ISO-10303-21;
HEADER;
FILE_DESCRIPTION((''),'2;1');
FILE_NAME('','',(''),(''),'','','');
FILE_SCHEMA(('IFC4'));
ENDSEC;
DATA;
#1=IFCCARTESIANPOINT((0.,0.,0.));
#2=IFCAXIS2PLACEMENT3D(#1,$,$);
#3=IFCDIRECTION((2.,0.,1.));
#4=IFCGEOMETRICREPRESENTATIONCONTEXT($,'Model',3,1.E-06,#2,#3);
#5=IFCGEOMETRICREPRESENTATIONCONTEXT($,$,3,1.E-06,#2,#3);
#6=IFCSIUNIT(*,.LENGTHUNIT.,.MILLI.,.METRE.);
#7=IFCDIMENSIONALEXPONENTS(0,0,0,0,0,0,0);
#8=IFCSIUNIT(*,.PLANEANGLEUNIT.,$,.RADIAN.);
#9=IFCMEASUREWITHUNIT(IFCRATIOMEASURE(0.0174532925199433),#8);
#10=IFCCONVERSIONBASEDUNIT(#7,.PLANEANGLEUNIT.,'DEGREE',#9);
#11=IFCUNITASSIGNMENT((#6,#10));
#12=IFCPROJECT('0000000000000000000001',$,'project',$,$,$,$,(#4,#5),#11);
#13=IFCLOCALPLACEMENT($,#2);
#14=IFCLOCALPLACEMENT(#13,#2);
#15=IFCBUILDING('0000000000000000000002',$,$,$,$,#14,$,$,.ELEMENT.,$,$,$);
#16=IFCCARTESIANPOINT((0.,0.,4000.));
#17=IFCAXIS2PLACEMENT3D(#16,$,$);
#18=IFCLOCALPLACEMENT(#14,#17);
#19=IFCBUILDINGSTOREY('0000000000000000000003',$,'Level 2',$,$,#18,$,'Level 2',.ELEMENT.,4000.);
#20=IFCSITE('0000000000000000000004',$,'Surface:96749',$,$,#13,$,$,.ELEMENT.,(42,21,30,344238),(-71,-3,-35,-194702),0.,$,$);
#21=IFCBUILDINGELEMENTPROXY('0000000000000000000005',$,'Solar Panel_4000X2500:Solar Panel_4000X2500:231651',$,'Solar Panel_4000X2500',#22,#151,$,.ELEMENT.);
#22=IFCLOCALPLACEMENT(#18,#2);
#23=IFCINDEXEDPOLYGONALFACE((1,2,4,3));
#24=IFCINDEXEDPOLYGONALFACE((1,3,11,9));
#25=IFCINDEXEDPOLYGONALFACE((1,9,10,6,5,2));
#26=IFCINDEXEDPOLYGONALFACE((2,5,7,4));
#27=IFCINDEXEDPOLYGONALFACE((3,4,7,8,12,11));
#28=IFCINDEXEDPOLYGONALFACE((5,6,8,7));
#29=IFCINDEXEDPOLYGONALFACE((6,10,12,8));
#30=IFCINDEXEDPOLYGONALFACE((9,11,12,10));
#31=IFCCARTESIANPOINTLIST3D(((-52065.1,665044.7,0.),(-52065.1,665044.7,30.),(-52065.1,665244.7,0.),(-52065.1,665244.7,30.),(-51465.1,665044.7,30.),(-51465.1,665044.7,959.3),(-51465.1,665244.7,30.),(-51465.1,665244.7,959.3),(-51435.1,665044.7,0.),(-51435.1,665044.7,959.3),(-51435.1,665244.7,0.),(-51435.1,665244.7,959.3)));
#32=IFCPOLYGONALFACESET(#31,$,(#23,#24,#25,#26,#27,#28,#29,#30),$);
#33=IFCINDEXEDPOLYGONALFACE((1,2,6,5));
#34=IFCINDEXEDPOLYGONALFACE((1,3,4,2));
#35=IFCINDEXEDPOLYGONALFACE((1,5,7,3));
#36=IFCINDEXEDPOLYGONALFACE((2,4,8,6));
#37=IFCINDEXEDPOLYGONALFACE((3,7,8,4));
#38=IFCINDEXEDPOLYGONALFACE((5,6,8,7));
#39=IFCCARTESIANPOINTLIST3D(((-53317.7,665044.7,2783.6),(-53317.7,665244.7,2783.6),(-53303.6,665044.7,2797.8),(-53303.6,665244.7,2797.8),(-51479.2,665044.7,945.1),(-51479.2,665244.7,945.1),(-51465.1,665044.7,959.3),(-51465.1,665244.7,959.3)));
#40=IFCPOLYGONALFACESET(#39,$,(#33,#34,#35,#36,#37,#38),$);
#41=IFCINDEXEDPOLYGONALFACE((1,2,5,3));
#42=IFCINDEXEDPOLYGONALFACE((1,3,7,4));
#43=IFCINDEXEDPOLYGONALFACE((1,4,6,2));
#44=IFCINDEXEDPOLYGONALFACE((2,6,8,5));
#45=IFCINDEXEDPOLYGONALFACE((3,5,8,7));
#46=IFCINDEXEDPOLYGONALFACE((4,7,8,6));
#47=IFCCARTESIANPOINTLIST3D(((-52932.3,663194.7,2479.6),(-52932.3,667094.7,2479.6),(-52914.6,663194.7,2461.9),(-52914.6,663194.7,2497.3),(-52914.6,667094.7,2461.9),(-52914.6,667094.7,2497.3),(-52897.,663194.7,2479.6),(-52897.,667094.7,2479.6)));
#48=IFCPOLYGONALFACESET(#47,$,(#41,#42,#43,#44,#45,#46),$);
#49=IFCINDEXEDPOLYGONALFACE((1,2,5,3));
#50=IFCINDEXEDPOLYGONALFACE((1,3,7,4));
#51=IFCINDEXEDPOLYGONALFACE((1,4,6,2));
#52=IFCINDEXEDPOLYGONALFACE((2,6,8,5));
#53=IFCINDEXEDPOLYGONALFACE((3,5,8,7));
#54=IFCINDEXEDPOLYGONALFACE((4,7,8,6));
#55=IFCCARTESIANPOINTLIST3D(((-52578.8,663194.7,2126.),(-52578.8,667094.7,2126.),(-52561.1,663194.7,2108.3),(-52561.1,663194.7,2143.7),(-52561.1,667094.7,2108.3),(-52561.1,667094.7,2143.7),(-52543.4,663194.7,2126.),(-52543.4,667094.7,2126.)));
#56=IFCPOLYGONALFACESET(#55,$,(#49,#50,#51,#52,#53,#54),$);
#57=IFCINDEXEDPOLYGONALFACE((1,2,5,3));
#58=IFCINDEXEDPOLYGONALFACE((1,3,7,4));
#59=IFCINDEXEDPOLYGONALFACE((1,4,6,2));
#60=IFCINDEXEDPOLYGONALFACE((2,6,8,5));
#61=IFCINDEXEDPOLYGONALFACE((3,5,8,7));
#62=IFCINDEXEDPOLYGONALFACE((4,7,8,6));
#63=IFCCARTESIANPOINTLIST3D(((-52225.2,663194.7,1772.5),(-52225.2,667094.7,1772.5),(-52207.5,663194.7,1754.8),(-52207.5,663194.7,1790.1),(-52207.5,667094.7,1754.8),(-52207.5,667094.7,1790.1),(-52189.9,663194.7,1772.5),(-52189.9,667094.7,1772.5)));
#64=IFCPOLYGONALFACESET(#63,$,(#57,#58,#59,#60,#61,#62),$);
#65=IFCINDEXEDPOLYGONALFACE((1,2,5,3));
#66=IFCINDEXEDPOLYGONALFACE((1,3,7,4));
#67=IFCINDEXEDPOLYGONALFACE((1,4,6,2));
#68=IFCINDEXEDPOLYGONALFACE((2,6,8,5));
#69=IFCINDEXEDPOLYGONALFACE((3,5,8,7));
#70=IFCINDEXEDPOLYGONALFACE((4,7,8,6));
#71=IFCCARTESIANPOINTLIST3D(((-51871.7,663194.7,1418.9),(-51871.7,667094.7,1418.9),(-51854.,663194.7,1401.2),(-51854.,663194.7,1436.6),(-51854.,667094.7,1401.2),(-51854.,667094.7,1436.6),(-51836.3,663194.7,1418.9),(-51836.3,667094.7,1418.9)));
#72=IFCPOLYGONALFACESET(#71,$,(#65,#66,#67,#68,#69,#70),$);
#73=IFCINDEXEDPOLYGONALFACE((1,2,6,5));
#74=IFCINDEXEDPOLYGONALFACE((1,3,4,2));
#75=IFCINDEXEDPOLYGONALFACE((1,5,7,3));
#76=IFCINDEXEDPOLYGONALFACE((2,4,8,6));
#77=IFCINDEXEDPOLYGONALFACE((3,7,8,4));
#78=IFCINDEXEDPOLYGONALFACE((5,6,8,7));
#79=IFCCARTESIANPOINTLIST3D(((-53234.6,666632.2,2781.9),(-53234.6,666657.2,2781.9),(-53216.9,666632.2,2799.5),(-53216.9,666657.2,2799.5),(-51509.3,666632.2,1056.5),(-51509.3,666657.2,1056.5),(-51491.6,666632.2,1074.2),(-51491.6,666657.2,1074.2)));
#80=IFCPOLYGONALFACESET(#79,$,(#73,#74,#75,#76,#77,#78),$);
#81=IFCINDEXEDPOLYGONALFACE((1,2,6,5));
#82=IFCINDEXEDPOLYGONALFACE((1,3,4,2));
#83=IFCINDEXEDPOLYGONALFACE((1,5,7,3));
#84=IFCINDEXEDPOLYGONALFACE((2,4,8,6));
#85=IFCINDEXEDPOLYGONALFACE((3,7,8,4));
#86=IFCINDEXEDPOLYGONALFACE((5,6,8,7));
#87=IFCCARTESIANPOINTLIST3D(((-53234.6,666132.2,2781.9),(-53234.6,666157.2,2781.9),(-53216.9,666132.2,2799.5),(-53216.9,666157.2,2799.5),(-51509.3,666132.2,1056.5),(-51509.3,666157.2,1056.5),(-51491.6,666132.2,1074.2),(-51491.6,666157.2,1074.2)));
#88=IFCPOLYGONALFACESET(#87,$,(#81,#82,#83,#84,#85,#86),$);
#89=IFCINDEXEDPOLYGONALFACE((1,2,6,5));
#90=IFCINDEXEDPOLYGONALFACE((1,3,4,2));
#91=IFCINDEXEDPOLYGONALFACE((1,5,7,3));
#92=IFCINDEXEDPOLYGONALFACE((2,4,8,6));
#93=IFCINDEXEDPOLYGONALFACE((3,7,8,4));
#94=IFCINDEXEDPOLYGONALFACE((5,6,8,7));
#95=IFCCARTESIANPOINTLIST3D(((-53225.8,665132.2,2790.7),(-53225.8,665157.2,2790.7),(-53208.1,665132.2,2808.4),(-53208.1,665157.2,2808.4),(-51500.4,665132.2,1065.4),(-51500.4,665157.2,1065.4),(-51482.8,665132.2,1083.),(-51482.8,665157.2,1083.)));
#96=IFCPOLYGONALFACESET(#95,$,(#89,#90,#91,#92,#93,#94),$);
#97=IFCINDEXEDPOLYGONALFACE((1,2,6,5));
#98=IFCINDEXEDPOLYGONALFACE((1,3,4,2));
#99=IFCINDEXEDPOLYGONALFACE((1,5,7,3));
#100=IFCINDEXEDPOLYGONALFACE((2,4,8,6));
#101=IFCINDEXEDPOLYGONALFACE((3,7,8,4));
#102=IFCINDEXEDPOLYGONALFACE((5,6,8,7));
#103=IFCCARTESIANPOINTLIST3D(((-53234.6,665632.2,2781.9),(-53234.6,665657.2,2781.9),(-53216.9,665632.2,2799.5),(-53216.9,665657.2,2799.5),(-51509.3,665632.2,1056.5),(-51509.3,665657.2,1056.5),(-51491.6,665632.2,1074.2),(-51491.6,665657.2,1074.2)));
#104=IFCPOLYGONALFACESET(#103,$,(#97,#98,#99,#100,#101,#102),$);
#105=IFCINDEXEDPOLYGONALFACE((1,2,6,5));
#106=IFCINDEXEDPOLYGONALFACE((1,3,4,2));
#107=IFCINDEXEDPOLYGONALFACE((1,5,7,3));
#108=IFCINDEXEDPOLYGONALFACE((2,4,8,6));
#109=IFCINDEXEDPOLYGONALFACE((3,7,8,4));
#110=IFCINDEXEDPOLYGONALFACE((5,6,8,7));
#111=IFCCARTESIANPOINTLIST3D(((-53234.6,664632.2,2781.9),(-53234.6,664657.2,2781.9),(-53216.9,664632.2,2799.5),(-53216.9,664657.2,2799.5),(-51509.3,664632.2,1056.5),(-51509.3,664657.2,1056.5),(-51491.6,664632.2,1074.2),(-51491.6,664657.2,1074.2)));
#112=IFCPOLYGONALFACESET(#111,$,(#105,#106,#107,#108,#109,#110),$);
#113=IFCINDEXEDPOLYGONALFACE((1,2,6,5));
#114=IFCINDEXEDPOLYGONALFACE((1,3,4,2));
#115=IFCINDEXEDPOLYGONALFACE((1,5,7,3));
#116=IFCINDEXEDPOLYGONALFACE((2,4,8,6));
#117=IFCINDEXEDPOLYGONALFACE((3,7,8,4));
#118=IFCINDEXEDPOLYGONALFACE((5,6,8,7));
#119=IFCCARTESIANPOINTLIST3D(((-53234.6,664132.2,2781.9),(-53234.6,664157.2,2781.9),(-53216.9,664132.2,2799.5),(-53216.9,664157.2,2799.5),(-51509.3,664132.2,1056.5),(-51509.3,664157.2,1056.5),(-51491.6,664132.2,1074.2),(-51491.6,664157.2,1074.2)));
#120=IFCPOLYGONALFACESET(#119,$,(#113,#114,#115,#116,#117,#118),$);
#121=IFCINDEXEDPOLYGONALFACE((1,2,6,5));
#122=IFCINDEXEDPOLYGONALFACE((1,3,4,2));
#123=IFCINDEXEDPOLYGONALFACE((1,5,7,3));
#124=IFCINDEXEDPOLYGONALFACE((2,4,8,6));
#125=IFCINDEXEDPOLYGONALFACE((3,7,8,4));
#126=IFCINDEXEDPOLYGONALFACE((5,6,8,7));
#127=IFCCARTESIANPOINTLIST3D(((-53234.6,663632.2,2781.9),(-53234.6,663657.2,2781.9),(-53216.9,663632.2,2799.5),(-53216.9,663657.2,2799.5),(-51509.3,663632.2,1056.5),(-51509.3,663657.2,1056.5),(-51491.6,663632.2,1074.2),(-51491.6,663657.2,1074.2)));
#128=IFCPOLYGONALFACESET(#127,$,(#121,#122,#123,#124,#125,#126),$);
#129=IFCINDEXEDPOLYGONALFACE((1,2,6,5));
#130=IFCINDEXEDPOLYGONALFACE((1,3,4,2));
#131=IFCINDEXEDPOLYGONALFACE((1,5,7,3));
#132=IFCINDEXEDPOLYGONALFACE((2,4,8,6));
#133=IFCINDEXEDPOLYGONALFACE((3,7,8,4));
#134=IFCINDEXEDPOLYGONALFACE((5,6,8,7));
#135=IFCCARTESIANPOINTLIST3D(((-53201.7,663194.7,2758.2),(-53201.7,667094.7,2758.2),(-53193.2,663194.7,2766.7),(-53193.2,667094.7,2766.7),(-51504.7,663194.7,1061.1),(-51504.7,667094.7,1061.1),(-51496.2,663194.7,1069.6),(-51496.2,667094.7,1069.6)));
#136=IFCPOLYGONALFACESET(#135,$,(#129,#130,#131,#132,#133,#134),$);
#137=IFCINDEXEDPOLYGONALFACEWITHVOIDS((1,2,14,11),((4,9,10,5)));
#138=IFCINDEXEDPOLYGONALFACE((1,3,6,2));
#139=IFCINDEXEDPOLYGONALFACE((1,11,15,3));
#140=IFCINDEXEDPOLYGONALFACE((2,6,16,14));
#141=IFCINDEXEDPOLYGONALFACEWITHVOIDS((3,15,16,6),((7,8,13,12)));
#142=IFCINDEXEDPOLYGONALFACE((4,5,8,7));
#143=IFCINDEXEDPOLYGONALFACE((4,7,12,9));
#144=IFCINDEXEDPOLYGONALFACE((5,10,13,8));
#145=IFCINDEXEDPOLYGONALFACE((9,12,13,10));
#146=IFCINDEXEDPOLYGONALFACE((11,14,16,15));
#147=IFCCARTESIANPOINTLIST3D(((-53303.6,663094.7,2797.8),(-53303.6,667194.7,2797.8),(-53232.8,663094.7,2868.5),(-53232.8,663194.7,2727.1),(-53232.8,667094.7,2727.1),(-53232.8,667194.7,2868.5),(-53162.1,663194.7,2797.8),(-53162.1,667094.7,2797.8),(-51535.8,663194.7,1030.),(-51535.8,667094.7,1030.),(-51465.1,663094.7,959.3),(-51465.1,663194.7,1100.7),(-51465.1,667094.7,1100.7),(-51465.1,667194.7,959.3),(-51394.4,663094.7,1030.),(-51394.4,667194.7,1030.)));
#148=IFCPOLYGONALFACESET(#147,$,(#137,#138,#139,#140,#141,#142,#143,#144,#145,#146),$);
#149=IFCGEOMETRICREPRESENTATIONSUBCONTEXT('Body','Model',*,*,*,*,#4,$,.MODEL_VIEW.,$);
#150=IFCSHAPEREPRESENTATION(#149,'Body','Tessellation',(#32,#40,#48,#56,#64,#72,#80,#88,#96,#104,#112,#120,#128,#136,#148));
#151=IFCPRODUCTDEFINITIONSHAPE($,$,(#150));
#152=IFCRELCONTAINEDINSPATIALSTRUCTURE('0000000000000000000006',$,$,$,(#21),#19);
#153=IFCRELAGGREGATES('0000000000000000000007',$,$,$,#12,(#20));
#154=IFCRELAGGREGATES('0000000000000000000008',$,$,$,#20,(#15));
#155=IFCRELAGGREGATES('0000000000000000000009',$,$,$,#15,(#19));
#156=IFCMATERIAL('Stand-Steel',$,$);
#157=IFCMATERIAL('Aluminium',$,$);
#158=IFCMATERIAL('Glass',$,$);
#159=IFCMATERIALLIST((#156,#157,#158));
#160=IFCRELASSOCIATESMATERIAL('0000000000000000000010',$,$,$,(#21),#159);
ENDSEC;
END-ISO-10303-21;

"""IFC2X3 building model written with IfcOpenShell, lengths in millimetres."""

from ifc_helpers import new_model, entity, si_unit, converted_unit, direction, frame, frame_2d, origin, origin_2d_with_axis, place, context, subcontext, project, spatial, polyline, rectangle, outline, extrude, source, transform, mapped, material, material_list, element, save


model = new_model("IFC2X3")

# Units and contexts
model_context = context("Model", 3, precision=1e-06, world=origin(), true_north=direction((2.0, 0.0, 1.0)))
context_of_model = context(None, 3, precision=1e-06, world=origin(), true_north=direction((2.0, 0.0, 1.0)))
body_context = subcontext(model_context, "Body", "Model", "MODEL_VIEW")
ifc_project = project(units=[si_unit("LENGTHUNIT", "METRE", prefix="MILLI"), converted_unit("PLANEANGLEUNIT", "DEGREE", entity("IfcRatioMeasure", 0.0174532925199433), si_unit("PLANEANGLEUNIT", "RADIAN"), dimensions=[0, 0, 0, 0, 0, 0, 0])], contexts=[model_context, context_of_model])

# Site, building, storey
site_placement = place(None, origin())
site = spatial("IfcSite", under=ifc_project, at=site_placement, Name="Surface:96749", CompositionType="ELEMENT", RefLatitude=(42, 21, 30, 344238), RefLongitude=(-71, -3, -35, -194702), RefElevation=0.0)
building_placement = place(site_placement, origin())
building = spatial("IfcBuilding", under=site, at=building_placement, CompositionType="ELEMENT")
storey_placement = place(building_placement, frame((0.0, 0.0, 4000.0)))
storey = spatial("IfcBuildingStorey", under=building, at=storey_placement, Name="Level 2", LongName="Level 2", CompositionType="ELEMENT", Elevation=4000.0)

# Building element proxy
ifc_material_1 = material(Name="Stand-Steel")
ifc_material_2 = material(Name="Aluminium")
ifc_material_3 = material(Name="Glass")
shared_shape = source(origin(), body_context, "Body", "SweptSolid", [
    extrude(outline(polyline([(-629.5, -220.0), (329.8, -220.0), (329.8, 410.0), (299.8, 410.0), (299.8, -190.0), (-629.5, -190.0), (-629.5, -220.0)])), frame((-190.0, -100.0, 299.8), z_axis=(0.0, 1.0, 0.0), x_axis=(0.0, 0.0, -1.0)), (0.0, 0.0, 1.0), 200.0),
    extrude(rectangle(XDim=20.0, YDim=200.0, at=frame_2d((0.0, 0.0), x_axis=(0.0, 1.0))), frame((-7.1, 0.0, 922.2), z_axis=(-0.707107, 0.0, 0.707107), x_axis=(0.0, 1.0, 0.0)), (0.0, 0.0, 1.0), 2600.0),
    extrude(rectangle(XDim=25.0, YDim=25.0, at=frame_2d((0.0, 0.0), x_axis=(1.0, 0.0))), frame((-1449.6, -1950.0, 2449.6), z_axis=(0.0, 1.0, 0.0), x_axis=(-0.707107, 0.0, -0.707107)), (0.0, 0.0, 1.0), 3900.0),
    extrude(rectangle(XDim=25.0, YDim=25.0, at=origin_2d_with_axis()), frame((-1096.0, -1950.0, 2096.0), z_axis=(0.0, 1.0, 0.0), x_axis=(-0.707107, 0.0, -0.707107)), (0.0, 0.0, 1.0), 3900.0),
    extrude(rectangle(XDim=25.0, YDim=25.0, at=origin_2d_with_axis()), frame((-742.5, -1950.0, 1742.5), z_axis=(0.0, 1.0, 0.0), x_axis=(-0.707107, 0.0, -0.707107)), (0.0, 0.0, 1.0), 3900.0),
    extrude(rectangle(XDim=25.0, YDim=25.0, at=frame_2d((0.0, 0.0), x_axis=(1.0, 0.0))), frame((-388.9, -1950.0, 1388.9), z_axis=(0.0, 1.0, 0.0), x_axis=(-0.707107, 0.0, -0.707107)), (0.0, 0.0, 1.0), 3900.0),
    extrude(rectangle(XDim=25.0, YDim=25.0, at=frame_2d((0.0, 0.0), x_axis=(0.0, 1.0))), frame((-35.4, 1500.0, 1035.4), z_axis=(-0.707107, 0.0, 0.707107), x_axis=(0.0, 1.0, 0.0)), (0.0, 0.0, 1.0), 2440.0),
    extrude(rectangle(XDim=25.0, YDim=25.0, at=frame_2d((0.0, 0.0), x_axis=(0.0, 1.0))), frame((-35.4, 1000.0, 1035.4), z_axis=(-0.707107, 0.0, 0.707107), x_axis=(0.0, 1.0, 0.0)), (0.0, 0.0, 1.0), 2440.0),
    extrude(rectangle(XDim=25.0, YDim=25.0, at=frame_2d((0.0, 0.0), x_axis=(0.0, 1.0))), frame((-26.5, 0.0, 1044.2), z_axis=(-0.707107, 0.0, 0.707107), x_axis=(0.0, -1.0, 0.0)), (0.0, 0.0, 1.0), 2440.0),
    extrude(rectangle(XDim=25.0, YDim=25.0, at=frame_2d((0.0, 0.0), x_axis=(0.0, 1.0))), frame((-35.4, 500.0, 1035.4), z_axis=(-0.707107, 0.0, 0.707107), x_axis=(0.0, 1.0, 0.0)), (0.0, 0.0, 1.0), 2440.0),
    extrude(rectangle(XDim=25.0, YDim=25.0, at=frame_2d((0.0, 0.0), x_axis=(0.0, 1.0))), frame((-35.4, -500.0, 1035.4), z_axis=(-0.707107, 0.0, 0.707107), x_axis=(0.0, 1.0, 0.0)), (0.0, 0.0, 1.0), 2440.0),
    extrude(rectangle(XDim=25.0, YDim=25.0, at=frame_2d((0.0, 0.0), x_axis=(0.0, 1.0))), frame((-35.4, -1000.0, 1035.4), z_axis=(-0.707107, 0.0, 0.707107), x_axis=(0.0, 1.0, 0.0)), (0.0, 0.0, 1.0), 2440.0),
    extrude(rectangle(XDim=25.0, YDim=25.0, at=frame_2d((0.0, 0.0), x_axis=(0.0, 1.0))), frame((-35.4, -1500.0, 1035.4), z_axis=(-0.707107, 0.0, 0.707107), x_axis=(0.0, 1.0, 0.0)), (0.0, 0.0, 1.0), 2440.0),
    extrude(rectangle(XDim=2400.0, YDim=12.0, at=frame_2d((0.0, 0.0), x_axis=(1.0, 0.0))), frame((-883.9, -1950.0, 1883.9), z_axis=(0.0, 1.0, 0.0), x_axis=(0.707107, 0.0, -0.707107)), (0.0, 0.0, 1.0), 3900.0),
    extrude(outline(polyline([(-2050.0, -1300.0), (2050.0, -1300.0), (2050.0, 1300.0), (-2050.0, 1300.0), (-2050.0, -1300.0)]), holes=[polyline([(1950.0, -1200.0), (-1950.0, -1200.0), (-1950.0, 1200.0), (1950.0, 1200.0), (1950.0, -1200.0)])]), frame((-919.2, 0.0, 1848.5), z_axis=(0.707107, 0.0, 0.707107), x_axis=(0.0, 1.0, 0.0)), (0.0, 0.0, 1.0), 100.0),
])
ifc_material_list_1 = material_list([ifc_material_1, ifc_material_2, ifc_material_3])
proxy_1_placement = place(storey_placement, frame((-51465.1, 665144.7, 30.0)))
element("IfcBuildingElementProxy", 1, at=proxy_1_placement, inside=storey, material=ifc_material_list_1, Name="Solar Panel_4000X2500:Solar Panel_4000X2500:231651", ObjectType="Solar Panel_4000X2500", CompositionType="ELEMENT", context=body_context, shape_type="MappedRepresentation", body=[
    mapped(shared_shape, transform((0.0, 0.0, 0.0), scale=1.0)),
])

save(model, "model.ifc")
